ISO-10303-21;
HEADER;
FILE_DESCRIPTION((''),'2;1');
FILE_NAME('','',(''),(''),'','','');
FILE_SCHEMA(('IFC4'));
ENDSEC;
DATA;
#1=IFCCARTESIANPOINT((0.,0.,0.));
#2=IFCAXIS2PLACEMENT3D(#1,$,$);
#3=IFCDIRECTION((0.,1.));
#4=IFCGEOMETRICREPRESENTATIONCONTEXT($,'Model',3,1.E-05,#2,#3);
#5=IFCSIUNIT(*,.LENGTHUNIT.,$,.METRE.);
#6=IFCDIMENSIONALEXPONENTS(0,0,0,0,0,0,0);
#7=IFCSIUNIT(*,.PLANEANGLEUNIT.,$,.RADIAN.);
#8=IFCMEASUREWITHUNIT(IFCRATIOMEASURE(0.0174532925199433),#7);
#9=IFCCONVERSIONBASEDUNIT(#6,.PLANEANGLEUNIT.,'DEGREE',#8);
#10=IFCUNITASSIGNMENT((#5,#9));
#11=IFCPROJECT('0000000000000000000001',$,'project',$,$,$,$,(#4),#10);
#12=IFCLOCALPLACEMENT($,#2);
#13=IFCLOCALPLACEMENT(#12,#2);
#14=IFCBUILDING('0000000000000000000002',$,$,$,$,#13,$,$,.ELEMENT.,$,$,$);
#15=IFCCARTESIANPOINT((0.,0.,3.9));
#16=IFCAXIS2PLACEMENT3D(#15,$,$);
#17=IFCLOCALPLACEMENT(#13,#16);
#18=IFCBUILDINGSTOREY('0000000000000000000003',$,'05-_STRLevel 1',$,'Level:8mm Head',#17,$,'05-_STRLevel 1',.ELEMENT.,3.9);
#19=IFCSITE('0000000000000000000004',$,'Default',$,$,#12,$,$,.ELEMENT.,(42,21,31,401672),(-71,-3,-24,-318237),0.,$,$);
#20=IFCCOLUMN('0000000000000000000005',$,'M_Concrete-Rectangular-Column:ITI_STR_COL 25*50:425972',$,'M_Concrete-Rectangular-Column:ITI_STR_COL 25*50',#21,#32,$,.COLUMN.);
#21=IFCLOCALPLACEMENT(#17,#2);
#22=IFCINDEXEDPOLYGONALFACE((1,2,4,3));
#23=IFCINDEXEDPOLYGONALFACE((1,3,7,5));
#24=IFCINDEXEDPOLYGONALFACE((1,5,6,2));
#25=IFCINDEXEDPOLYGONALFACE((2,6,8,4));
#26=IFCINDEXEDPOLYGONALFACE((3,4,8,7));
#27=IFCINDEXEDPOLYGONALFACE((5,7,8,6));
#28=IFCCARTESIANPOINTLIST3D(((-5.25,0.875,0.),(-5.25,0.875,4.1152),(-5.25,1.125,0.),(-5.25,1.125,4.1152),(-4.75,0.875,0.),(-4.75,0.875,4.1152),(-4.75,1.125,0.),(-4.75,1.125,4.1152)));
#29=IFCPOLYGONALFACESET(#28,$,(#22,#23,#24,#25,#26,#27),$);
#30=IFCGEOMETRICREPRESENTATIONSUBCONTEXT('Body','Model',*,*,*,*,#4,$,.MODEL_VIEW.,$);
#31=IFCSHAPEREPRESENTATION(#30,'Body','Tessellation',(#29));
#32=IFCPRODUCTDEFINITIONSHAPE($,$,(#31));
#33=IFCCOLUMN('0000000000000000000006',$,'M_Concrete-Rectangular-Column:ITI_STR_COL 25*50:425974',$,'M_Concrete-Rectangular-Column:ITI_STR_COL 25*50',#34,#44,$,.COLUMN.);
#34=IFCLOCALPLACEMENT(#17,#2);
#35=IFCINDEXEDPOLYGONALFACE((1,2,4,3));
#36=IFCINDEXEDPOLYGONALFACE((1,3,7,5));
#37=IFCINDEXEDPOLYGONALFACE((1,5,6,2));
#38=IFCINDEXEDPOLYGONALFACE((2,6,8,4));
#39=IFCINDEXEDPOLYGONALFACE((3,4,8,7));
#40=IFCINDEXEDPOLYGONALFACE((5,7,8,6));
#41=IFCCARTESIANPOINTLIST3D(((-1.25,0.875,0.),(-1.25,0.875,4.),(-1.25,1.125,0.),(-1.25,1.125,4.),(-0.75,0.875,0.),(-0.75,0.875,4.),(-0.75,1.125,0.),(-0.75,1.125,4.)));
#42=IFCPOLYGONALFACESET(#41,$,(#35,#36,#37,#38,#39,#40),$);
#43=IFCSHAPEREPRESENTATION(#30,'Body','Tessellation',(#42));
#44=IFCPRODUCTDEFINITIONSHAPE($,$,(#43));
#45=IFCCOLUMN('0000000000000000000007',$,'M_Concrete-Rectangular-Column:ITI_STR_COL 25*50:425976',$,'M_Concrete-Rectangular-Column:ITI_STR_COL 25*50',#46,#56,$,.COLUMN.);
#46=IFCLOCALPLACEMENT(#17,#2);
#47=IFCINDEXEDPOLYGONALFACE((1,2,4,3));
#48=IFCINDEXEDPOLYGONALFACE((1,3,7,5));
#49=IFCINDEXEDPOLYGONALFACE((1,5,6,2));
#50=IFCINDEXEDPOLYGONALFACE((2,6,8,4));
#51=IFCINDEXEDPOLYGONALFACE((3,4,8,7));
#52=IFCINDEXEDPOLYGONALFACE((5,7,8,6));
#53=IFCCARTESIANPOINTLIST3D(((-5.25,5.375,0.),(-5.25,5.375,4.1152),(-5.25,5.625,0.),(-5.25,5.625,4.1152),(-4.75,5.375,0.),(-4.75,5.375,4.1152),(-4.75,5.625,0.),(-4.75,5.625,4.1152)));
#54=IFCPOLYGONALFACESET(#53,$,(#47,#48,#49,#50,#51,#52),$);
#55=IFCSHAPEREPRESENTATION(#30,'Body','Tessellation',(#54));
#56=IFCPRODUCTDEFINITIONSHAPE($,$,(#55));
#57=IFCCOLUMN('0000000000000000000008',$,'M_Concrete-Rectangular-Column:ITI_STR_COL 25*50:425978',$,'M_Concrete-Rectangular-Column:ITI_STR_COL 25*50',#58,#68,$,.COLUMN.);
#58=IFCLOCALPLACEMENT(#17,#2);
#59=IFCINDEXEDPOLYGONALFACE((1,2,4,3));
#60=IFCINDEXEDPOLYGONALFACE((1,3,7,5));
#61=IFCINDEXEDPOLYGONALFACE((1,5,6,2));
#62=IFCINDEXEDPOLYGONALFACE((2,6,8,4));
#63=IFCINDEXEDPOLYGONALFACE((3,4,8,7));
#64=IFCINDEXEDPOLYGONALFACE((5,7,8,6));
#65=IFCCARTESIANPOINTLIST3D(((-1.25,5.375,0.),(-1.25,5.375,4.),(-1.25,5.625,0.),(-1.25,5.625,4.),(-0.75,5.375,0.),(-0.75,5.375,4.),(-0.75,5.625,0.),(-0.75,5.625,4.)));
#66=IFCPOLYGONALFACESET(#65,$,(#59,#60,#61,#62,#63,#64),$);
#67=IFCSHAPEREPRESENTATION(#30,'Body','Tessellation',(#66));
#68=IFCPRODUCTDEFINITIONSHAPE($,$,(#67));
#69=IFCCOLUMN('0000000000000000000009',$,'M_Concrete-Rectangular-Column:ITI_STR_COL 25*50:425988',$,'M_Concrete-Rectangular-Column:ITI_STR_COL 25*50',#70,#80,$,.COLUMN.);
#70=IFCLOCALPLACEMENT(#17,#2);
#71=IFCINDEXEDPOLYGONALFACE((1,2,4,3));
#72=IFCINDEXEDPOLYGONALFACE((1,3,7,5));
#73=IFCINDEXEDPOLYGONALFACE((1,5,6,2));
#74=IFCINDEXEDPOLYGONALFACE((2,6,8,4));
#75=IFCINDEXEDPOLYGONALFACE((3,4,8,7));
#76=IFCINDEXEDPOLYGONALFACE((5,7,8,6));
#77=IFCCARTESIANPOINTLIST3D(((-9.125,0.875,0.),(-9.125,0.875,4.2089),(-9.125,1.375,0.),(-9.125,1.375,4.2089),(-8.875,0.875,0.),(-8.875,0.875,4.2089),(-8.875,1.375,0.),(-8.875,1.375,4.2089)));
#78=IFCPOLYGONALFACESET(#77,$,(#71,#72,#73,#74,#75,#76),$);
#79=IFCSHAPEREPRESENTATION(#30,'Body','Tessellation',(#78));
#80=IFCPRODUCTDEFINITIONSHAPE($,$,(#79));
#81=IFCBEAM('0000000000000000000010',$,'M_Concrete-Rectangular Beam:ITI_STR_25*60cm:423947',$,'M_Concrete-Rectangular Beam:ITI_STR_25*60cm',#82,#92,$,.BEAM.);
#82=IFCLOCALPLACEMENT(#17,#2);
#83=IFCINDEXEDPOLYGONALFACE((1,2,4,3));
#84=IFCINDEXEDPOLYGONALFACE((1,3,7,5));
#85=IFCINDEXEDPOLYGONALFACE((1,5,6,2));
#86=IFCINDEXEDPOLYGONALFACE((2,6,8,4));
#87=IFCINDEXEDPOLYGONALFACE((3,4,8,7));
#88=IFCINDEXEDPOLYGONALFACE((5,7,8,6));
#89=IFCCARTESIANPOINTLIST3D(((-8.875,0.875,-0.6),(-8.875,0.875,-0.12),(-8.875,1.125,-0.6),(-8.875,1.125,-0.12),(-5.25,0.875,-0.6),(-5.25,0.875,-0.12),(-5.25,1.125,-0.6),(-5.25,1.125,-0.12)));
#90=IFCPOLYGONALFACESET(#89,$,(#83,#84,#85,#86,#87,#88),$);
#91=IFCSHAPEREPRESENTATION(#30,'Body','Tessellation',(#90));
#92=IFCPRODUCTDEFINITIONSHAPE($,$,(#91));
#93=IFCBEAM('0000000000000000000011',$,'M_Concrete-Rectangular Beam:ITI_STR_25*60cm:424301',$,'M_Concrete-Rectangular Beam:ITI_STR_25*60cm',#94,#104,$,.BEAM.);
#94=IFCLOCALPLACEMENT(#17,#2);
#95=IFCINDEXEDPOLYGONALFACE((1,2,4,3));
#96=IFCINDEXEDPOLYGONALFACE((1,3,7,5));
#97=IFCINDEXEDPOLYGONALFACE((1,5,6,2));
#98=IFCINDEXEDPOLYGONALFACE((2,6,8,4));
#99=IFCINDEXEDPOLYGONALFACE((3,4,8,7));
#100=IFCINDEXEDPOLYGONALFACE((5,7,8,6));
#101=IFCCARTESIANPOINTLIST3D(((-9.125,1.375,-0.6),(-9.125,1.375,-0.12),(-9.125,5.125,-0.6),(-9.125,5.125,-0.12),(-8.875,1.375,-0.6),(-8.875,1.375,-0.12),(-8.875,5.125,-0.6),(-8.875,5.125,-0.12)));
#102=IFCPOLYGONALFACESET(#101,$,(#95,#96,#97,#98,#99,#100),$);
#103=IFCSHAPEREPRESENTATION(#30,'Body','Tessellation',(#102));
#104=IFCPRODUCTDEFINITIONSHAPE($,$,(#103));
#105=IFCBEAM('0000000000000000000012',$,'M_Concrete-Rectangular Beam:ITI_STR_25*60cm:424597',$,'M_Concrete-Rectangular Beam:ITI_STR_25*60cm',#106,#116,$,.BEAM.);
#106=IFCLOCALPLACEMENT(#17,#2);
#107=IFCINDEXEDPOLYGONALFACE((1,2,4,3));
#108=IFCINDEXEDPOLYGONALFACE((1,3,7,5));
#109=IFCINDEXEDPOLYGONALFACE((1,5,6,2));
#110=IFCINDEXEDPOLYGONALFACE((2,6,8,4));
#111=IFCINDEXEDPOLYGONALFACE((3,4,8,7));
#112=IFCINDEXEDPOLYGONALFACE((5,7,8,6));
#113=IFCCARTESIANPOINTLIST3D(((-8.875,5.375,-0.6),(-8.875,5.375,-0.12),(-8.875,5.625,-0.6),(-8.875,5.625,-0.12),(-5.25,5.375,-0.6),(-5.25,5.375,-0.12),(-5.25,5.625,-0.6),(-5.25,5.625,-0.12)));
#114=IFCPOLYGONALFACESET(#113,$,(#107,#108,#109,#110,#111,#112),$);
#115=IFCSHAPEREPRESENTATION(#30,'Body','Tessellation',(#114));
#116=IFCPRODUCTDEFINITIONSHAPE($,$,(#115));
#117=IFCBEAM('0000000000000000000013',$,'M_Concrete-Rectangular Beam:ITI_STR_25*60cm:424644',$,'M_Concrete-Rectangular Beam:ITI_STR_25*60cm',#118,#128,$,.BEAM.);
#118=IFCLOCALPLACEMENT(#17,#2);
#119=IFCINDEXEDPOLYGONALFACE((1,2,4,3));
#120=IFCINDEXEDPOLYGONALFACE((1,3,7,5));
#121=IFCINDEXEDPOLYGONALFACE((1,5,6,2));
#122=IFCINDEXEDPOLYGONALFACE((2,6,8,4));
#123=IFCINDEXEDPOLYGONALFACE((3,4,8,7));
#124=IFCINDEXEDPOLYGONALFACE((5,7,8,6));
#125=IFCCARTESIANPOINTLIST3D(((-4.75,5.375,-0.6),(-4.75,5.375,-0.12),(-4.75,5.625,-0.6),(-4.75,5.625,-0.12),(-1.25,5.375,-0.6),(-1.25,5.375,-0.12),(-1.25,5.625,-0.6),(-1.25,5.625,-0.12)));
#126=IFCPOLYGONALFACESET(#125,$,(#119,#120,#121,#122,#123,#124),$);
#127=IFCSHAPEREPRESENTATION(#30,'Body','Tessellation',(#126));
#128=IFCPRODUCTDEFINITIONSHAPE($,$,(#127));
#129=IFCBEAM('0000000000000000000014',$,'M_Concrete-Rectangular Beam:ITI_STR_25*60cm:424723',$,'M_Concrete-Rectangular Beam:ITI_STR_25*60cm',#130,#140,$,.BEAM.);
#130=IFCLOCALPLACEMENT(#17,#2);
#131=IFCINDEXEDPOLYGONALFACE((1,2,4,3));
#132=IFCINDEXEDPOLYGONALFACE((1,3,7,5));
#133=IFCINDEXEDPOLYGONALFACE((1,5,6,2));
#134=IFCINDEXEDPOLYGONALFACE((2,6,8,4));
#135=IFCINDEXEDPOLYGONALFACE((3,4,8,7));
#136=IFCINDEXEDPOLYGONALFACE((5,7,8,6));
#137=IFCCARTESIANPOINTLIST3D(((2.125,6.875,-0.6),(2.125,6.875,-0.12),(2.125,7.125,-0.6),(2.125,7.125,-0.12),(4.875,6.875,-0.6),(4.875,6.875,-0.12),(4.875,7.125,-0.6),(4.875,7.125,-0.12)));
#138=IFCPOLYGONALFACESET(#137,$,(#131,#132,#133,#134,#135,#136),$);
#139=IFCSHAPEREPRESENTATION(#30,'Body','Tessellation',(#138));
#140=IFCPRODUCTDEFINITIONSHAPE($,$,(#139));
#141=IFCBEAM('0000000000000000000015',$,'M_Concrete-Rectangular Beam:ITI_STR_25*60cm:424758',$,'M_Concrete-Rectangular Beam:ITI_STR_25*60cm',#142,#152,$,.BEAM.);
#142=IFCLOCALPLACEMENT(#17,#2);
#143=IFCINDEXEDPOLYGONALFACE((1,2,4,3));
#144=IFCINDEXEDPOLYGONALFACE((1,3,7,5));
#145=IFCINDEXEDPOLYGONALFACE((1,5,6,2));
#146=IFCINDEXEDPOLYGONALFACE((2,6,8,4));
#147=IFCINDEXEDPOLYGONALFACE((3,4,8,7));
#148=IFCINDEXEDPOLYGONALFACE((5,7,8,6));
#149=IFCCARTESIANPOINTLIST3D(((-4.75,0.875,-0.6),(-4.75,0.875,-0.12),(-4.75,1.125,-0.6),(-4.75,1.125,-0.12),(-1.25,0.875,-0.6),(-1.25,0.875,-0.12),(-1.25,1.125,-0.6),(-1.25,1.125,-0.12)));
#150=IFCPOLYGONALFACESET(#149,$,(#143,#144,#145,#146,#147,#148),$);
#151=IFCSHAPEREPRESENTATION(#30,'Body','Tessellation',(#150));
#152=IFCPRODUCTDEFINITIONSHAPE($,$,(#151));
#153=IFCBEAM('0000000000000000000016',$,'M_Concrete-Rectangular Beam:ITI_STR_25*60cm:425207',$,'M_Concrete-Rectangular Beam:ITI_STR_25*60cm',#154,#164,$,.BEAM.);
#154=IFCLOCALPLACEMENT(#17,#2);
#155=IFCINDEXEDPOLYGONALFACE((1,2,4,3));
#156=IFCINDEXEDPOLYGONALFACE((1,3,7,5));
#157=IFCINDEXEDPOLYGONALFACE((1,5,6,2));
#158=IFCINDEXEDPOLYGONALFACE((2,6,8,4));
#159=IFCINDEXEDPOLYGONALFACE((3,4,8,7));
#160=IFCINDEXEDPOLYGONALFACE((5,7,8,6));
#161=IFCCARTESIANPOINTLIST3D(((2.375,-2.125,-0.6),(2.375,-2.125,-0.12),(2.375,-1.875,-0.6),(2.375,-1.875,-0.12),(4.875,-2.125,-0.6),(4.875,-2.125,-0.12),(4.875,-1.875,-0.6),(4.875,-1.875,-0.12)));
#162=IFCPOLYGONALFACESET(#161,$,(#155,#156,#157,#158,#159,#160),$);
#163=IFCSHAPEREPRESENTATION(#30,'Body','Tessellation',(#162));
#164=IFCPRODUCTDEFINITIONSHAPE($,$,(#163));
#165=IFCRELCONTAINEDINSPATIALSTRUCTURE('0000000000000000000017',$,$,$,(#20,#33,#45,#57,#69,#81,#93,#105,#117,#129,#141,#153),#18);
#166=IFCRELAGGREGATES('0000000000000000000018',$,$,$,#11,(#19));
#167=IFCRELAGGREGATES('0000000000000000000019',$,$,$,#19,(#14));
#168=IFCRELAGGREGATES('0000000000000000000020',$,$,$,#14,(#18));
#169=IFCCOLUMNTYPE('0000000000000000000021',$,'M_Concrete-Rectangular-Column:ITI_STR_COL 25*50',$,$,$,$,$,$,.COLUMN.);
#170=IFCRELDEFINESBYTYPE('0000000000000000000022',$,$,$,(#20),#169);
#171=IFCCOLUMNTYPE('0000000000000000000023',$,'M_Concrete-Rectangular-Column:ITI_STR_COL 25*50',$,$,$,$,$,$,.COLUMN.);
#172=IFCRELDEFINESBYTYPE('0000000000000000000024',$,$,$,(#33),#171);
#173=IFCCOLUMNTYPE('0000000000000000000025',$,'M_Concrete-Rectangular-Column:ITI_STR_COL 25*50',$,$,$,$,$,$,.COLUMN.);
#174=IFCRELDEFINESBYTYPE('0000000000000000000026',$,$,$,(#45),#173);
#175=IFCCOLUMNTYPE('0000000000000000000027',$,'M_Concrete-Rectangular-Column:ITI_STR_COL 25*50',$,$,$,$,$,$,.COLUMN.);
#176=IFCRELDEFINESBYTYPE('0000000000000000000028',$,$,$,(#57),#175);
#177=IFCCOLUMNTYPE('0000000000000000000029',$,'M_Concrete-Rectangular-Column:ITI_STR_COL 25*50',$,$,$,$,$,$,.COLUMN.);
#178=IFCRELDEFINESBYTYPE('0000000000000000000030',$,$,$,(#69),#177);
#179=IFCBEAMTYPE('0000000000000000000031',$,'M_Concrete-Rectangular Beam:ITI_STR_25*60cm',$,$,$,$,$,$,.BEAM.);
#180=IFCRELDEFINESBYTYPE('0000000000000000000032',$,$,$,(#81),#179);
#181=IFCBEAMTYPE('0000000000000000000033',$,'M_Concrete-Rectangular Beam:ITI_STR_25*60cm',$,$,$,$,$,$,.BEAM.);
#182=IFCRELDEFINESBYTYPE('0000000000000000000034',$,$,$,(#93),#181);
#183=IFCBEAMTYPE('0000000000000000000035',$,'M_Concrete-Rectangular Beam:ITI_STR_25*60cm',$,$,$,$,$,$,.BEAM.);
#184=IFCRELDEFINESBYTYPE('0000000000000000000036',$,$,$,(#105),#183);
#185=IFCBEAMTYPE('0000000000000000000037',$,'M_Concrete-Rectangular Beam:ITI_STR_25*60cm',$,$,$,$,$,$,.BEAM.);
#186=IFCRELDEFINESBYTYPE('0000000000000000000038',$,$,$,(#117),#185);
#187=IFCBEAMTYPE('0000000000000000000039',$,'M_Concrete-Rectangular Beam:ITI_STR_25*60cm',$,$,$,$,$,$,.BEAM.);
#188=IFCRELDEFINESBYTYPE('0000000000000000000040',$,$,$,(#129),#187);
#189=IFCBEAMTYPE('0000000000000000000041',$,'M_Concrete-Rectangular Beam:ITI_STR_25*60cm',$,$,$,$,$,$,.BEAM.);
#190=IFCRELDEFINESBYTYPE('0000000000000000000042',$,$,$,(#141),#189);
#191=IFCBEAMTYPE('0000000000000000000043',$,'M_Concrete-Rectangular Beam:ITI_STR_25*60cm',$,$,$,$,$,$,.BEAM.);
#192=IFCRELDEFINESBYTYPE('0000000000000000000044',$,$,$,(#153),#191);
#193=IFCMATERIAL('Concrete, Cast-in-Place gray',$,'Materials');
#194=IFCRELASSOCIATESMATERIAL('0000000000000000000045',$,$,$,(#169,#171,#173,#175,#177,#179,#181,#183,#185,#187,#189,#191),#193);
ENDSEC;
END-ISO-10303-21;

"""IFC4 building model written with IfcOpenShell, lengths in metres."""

from ifc_helpers import new_model, entity, si_unit, converted_unit, direction, frame, origin, place, context, subcontext, project, spatial, indexed_curve, outline, extrude, source, transform, mapped, material, type_object, type_shapes, element, save


model = new_model("IFC4")

# Units and contexts
model_context = context("Model", 3, precision=1e-05, world=origin(), true_north=direction((0.0, 1.0)))
body_context = subcontext(model_context, "Body", "Model", "MODEL_VIEW")
ifc_project = project(units=[si_unit("LENGTHUNIT", "METRE"), converted_unit("PLANEANGLEUNIT", "DEGREE", entity("IfcRatioMeasure", 0.0174532925199433), si_unit("PLANEANGLEUNIT", "RADIAN"), dimensions=[0, 0, 0, 0, 0, 0, 0])], contexts=[model_context])

# Site, building, storey
site_placement = place(None, origin())
site = spatial("IfcSite", under=ifc_project, at=site_placement, Name="Default", CompositionType="ELEMENT", RefLatitude=(42, 21, 31, 401672), RefLongitude=(-71, -3, -24, -318237), RefElevation=0.0)
building_placement = place(site_placement, origin())
building = spatial("IfcBuilding", under=site, at=building_placement, CompositionType="ELEMENT")
storey_placement = place(building_placement, frame((0.0, 0.0, 3.9)))
storey = spatial("IfcBuildingStorey", under=building, at=storey_placement, Name="05-_STRLevel 1", ObjectType="Level:8mm Head", LongName="05-_STRLevel 1", CompositionType="ELEMENT", Elevation=3.9)

# Columns
ifc_material_1 = material(Name="Concrete, Cast-in-Place gray", Category="Materials")
column_type_1 = type_object("IfcColumnType", Name="M_Concrete-Rectangular-Column:ITI_STR_COL 25*50", PredefinedType="COLUMN", material=ifc_material_1)
shared_shape_1 = source(origin(), body_context, "Body", "SweptSolid", [
    extrude(outline(indexed_curve([(-0.125, -0.25), (0.125, -0.25), (0.125, 0.25), (-0.125, 0.25), (-0.125, -0.25)], self_intersect=False)), frame((-5.0, 1.0, 3.9), z_axis=(0.0, 0.0, 1.0), x_axis=(0.0, -1.0, 0.0)), (0.0, 0.0, 1.0), 4.1152),
])
type_shapes(column_type_1, [shared_shape_1])
column_1_placement = place(storey_placement, frame((0.0, 0.0, -3.9)))
element("IfcColumn", 1, at=column_1_placement, inside=storey, type_object=column_type_1, Name="M_Concrete-Rectangular-Column:ITI_STR_COL 25*50:425972", ObjectType="M_Concrete-Rectangular-Column:ITI_STR_COL 25*50", PredefinedType="COLUMN", context=body_context, shape_type="MappedRepresentation", body=[
    mapped(shared_shape_1, transform((0.0, 0.0, 0.0), scale=1.0)),
])
column_type_2 = type_object("IfcColumnType", Name="M_Concrete-Rectangular-Column:ITI_STR_COL 25*50", PredefinedType="COLUMN", material=ifc_material_1)
shared_shape_2 = source(origin(), body_context, "Body", "SweptSolid", [
    extrude(outline(indexed_curve([(-0.125, -0.25), (0.125, -0.25), (0.125, 0.25), (-0.125, 0.25), (-0.125, -0.25)], self_intersect=False)), frame((-1.0, 1.0, 3.9), z_axis=(0.0, 0.0, 1.0), x_axis=(0.0, -1.0, 0.0)), (0.0, 0.0, 1.0), 4.0),
])
type_shapes(column_type_2, [shared_shape_2])
column_2_placement = place(storey_placement, frame((0.0, 0.0, -3.9)))
element("IfcColumn", 2, at=column_2_placement, inside=storey, type_object=column_type_2, Name="M_Concrete-Rectangular-Column:ITI_STR_COL 25*50:425974", ObjectType="M_Concrete-Rectangular-Column:ITI_STR_COL 25*50", PredefinedType="COLUMN", context=body_context, shape_type="MappedRepresentation", body=[
    mapped(shared_shape_2, transform((0.0, 0.0, 0.0), scale=1.0)),
])
column_type_3 = type_object("IfcColumnType", Name="M_Concrete-Rectangular-Column:ITI_STR_COL 25*50", PredefinedType="COLUMN", material=ifc_material_1)
shared_shape_3 = source(origin(), body_context, "Body", "SweptSolid", [
    extrude(outline(indexed_curve([(-0.125, -0.25), (0.125, -0.25), (0.125, 0.25), (-0.125, 0.25), (-0.125, -0.25)], self_intersect=False)), frame((-5.0, 5.5, 3.9), z_axis=(0.0, 0.0, 1.0), x_axis=(0.0, -1.0, 0.0)), (0.0, 0.0, 1.0), 4.1152),
])
type_shapes(column_type_3, [shared_shape_3])
column_3_placement = place(storey_placement, frame((0.0, 0.0, -3.9)))
element("IfcColumn", 3, at=column_3_placement, inside=storey, type_object=column_type_3, Name="M_Concrete-Rectangular-Column:ITI_STR_COL 25*50:425976", ObjectType="M_Concrete-Rectangular-Column:ITI_STR_COL 25*50", PredefinedType="COLUMN", context=body_context, shape_type="MappedRepresentation", body=[
    mapped(shared_shape_3, transform((0.0, 0.0, 0.0), scale=1.0)),
])
column_type_4 = type_object("IfcColumnType", Name="M_Concrete-Rectangular-Column:ITI_STR_COL 25*50", PredefinedType="COLUMN", material=ifc_material_1)
shared_shape_4 = source(origin(), body_context, "Body", "SweptSolid", [
    extrude(outline(indexed_curve([(-0.125, -0.25), (0.125, -0.25), (0.125, 0.25), (-0.125, 0.25), (-0.125, -0.25)], self_intersect=False)), frame((-1.0, 5.5, 3.9), z_axis=(0.0, 0.0, 1.0), x_axis=(0.0, -1.0, 0.0)), (0.0, 0.0, 1.0), 4.0),
])
type_shapes(column_type_4, [shared_shape_4])
column_4_placement = place(storey_placement, frame((0.0, 0.0, -3.9)))
element("IfcColumn", 4, at=column_4_placement, inside=storey, type_object=column_type_4, Name="M_Concrete-Rectangular-Column:ITI_STR_COL 25*50:425978", ObjectType="M_Concrete-Rectangular-Column:ITI_STR_COL 25*50", PredefinedType="COLUMN", context=body_context, shape_type="MappedRepresentation", body=[
    mapped(shared_shape_4, transform((0.0, 0.0, 0.0), scale=1.0)),
])
column_type_5 = type_object("IfcColumnType", Name="M_Concrete-Rectangular-Column:ITI_STR_COL 25*50", PredefinedType="COLUMN", material=ifc_material_1)
shared_shape_5 = source(origin(), body_context, "Body", "SweptSolid", [
    extrude(outline(indexed_curve([(-0.25, -0.125), (0.25, -0.125), (0.25, 0.125), (-0.25, 0.125), (-0.25, -0.125)], self_intersect=False)), frame((-9.0, 1.125, 3.9), z_axis=(0.0, 0.0, 1.0), x_axis=(0.0, -1.0, 0.0)), (0.0, 0.0, 1.0), 4.2089),
])
type_shapes(column_type_5, [shared_shape_5])
column_5_placement = place(storey_placement, frame((0.0, 0.0, -3.9)))
element("IfcColumn", 5, at=column_5_placement, inside=storey, type_object=column_type_5, Name="M_Concrete-Rectangular-Column:ITI_STR_COL 25*50:425988", ObjectType="M_Concrete-Rectangular-Column:ITI_STR_COL 25*50", PredefinedType="COLUMN", context=body_context, shape_type="MappedRepresentation", body=[
    mapped(shared_shape_5, transform((0.0, 0.0, 0.0), scale=1.0)),
])

# Beams
beam_type_1 = type_object("IfcBeamType", Name="M_Concrete-Rectangular Beam:ITI_STR_25*60cm", PredefinedType="BEAM", material=ifc_material_1)
shared_shape_6 = source(origin(), body_context, "Body", "SweptSolid", [
    extrude(outline(indexed_curve([(-0.24, -0.125), (0.24, -0.125), (0.24, 0.125), (-0.24, 0.125), (-0.24, -0.125)], self_intersect=False)), frame((-8.875, 1.0, 3.54), z_axis=(1.0, 0.0, 0.0), x_axis=(0.0, 0.0, -1.0)), (0.0, 0.0, 1.0), 3.625),
])
type_shapes(beam_type_1, [shared_shape_6])
beam_1_placement = place(storey_placement, frame((0.0, 0.0, -3.9)))
element("IfcBeam", 6, at=beam_1_placement, inside=storey, type_object=beam_type_1, Name="M_Concrete-Rectangular Beam:ITI_STR_25*60cm:423947", ObjectType="M_Concrete-Rectangular Beam:ITI_STR_25*60cm", PredefinedType="BEAM", context=body_context, shape_type="MappedRepresentation", body=[
    mapped(shared_shape_6, transform((0.0, 0.0, 0.0), scale=1.0)),
])
beam_type_2 = type_object("IfcBeamType", Name="M_Concrete-Rectangular Beam:ITI_STR_25*60cm", PredefinedType="BEAM", material=ifc_material_1)
shared_shape_7 = source(origin(), body_context, "Body", "SweptSolid", [
    extrude(outline(indexed_curve([(-0.125, -0.24), (0.125, -0.24), (0.125, 0.24), (-0.125, 0.24), (-0.125, -0.24)], self_intersect=False)), frame((-9.0, 5.125, 3.54), z_axis=(0.0, -1.0, 0.0), x_axis=(-1.0, 0.0, 0.0)), (0.0, 0.0, 1.0), 3.75),
])
type_shapes(beam_type_2, [shared_shape_7])
beam_2_placement = place(storey_placement, frame((0.0, 0.0, -3.9)))
element("IfcBeam", 7, at=beam_2_placement, inside=storey, type_object=beam_type_2, Name="M_Concrete-Rectangular Beam:ITI_STR_25*60cm:424301", ObjectType="M_Concrete-Rectangular Beam:ITI_STR_25*60cm", PredefinedType="BEAM", context=body_context, shape_type="MappedRepresentation", body=[
    mapped(shared_shape_7, transform((0.0, 0.0, 0.0), scale=1.0)),
])
beam_type_3 = type_object("IfcBeamType", Name="M_Concrete-Rectangular Beam:ITI_STR_25*60cm", PredefinedType="BEAM", material=ifc_material_1)
shared_shape_8 = source(origin(), body_context, "Body", "SweptSolid", [
    extrude(outline(indexed_curve([(-0.24, -0.125), (0.24, -0.125), (0.24, 0.125), (-0.24, 0.125), (-0.24, -0.125)], self_intersect=False)), frame((-8.875, 5.5, 3.54), z_axis=(1.0, 0.0, 0.0), x_axis=(0.0, 0.0, -1.0)), (0.0, 0.0, 1.0), 3.625),
])
type_shapes(beam_type_3, [shared_shape_8])
beam_3_placement = place(storey_placement, frame((0.0, 0.0, -3.9)))
element("IfcBeam", 8, at=beam_3_placement, inside=storey, type_object=beam_type_3, Name="M_Concrete-Rectangular Beam:ITI_STR_25*60cm:424597", ObjectType="M_Concrete-Rectangular Beam:ITI_STR_25*60cm", PredefinedType="BEAM", context=body_context, shape_type="MappedRepresentation", body=[
    mapped(shared_shape_8, transform((0.0, 0.0, 0.0), scale=1.0)),
])
beam_type_4 = type_object("IfcBeamType", Name="M_Concrete-Rectangular Beam:ITI_STR_25*60cm", PredefinedType="BEAM", material=ifc_material_1)
shared_shape_9 = source(origin(), body_context, "Body", "SweptSolid", [
    extrude(outline(indexed_curve([(-0.24, -0.125), (0.24, -0.125), (0.24, 0.125), (-0.24, 0.125), (-0.24, -0.125)], self_intersect=False)), frame((-4.75, 5.5, 3.54), z_axis=(1.0, 0.0, 0.0), x_axis=(0.0, 0.0, -1.0)), (0.0, 0.0, 1.0), 3.5),
])
type_shapes(beam_type_4, [shared_shape_9])
beam_4_placement = place(storey_placement, frame((0.0, 0.0, -3.9)))
element("IfcBeam", 9, at=beam_4_placement, inside=storey, type_object=beam_type_4, Name="M_Concrete-Rectangular Beam:ITI_STR_25*60cm:424644", ObjectType="M_Concrete-Rectangular Beam:ITI_STR_25*60cm", PredefinedType="BEAM", context=body_context, shape_type="MappedRepresentation", body=[
    mapped(shared_shape_9, transform((0.0, 0.0, 0.0), scale=1.0)),
])
beam_type_5 = type_object("IfcBeamType", Name="M_Concrete-Rectangular Beam:ITI_STR_25*60cm", PredefinedType="BEAM", material=ifc_material_1)
shared_shape_10 = source(origin(), body_context, "Body", "SweptSolid", [
    extrude(outline(indexed_curve([(-0.24, -0.125), (0.24, -0.125), (0.24, 0.125), (-0.24, 0.125), (-0.24, -0.125)], self_intersect=False)), frame((2.125, 7.0, 3.54), z_axis=(1.0, 0.0, 0.0), x_axis=(0.0, 0.0, -1.0)), (0.0, 0.0, 1.0), 2.75),
])
type_shapes(beam_type_5, [shared_shape_10])
beam_5_placement = place(storey_placement, frame((0.0, 0.0, -3.9)))
element("IfcBeam", 10, at=beam_5_placement, inside=storey, type_object=beam_type_5, Name="M_Concrete-Rectangular Beam:ITI_STR_25*60cm:424723", ObjectType="M_Concrete-Rectangular Beam:ITI_STR_25*60cm", PredefinedType="BEAM", context=body_context, shape_type="MappedRepresentation", body=[
    mapped(shared_shape_10, transform((0.0, 0.0, 0.0), scale=1.0)),
])
beam_type_6 = type_object("IfcBeamType", Name="M_Concrete-Rectangular Beam:ITI_STR_25*60cm", PredefinedType="BEAM", material=ifc_material_1)
shared_shape_11 = source(origin(), body_context, "Body", "SweptSolid", [
    extrude(outline(indexed_curve([(-0.24, -0.125), (0.24, -0.125), (0.24, 0.125), (-0.24, 0.125), (-0.24, -0.125)], self_intersect=False)), frame((-4.75, 1.0, 3.54), z_axis=(1.0, 0.0, 0.0), x_axis=(0.0, 0.0, -1.0)), (0.0, 0.0, 1.0), 3.5),
])
type_shapes(beam_type_6, [shared_shape_11])
beam_6_placement = place(storey_placement, frame((0.0, 0.0, -3.9)))
element("IfcBeam", 11, at=beam_6_placement, inside=storey, type_object=beam_type_6, Name="M_Concrete-Rectangular Beam:ITI_STR_25*60cm:424758", ObjectType="M_Concrete-Rectangular Beam:ITI_STR_25*60cm", PredefinedType="BEAM", context=body_context, shape_type="MappedRepresentation", body=[
    mapped(shared_shape_11, transform((0.0, 0.0, 0.0), scale=1.0)),
])
beam_type_7 = type_object("IfcBeamType", Name="M_Concrete-Rectangular Beam:ITI_STR_25*60cm", PredefinedType="BEAM", material=ifc_material_1)
shared_shape_12 = source(origin(), body_context, "Body", "SweptSolid", [
    extrude(outline(indexed_curve([(-0.24, -0.125), (0.24, -0.125), (0.24, 0.125), (-0.24, 0.125), (-0.24, -0.125)], self_intersect=False)), frame((4.875, -2.0, 3.54), z_axis=(-1.0, 0.0, 0.0), x_axis=(0.0, 0.0, -1.0)), (0.0, 0.0, 1.0), 2.5),
])
type_shapes(beam_type_7, [shared_shape_12])
beam_7_placement = place(storey_placement, frame((0.0, 0.0, -3.9)))
element("IfcBeam", 12, at=beam_7_placement, inside=storey, type_object=beam_type_7, Name="M_Concrete-Rectangular Beam:ITI_STR_25*60cm:425207", ObjectType="M_Concrete-Rectangular Beam:ITI_STR_25*60cm", PredefinedType="BEAM", context=body_context, shape_type="MappedRepresentation", body=[
    mapped(shared_shape_12, transform((0.0, 0.0, 0.0), scale=1.0)),
])

save(model, "model.ifc")
